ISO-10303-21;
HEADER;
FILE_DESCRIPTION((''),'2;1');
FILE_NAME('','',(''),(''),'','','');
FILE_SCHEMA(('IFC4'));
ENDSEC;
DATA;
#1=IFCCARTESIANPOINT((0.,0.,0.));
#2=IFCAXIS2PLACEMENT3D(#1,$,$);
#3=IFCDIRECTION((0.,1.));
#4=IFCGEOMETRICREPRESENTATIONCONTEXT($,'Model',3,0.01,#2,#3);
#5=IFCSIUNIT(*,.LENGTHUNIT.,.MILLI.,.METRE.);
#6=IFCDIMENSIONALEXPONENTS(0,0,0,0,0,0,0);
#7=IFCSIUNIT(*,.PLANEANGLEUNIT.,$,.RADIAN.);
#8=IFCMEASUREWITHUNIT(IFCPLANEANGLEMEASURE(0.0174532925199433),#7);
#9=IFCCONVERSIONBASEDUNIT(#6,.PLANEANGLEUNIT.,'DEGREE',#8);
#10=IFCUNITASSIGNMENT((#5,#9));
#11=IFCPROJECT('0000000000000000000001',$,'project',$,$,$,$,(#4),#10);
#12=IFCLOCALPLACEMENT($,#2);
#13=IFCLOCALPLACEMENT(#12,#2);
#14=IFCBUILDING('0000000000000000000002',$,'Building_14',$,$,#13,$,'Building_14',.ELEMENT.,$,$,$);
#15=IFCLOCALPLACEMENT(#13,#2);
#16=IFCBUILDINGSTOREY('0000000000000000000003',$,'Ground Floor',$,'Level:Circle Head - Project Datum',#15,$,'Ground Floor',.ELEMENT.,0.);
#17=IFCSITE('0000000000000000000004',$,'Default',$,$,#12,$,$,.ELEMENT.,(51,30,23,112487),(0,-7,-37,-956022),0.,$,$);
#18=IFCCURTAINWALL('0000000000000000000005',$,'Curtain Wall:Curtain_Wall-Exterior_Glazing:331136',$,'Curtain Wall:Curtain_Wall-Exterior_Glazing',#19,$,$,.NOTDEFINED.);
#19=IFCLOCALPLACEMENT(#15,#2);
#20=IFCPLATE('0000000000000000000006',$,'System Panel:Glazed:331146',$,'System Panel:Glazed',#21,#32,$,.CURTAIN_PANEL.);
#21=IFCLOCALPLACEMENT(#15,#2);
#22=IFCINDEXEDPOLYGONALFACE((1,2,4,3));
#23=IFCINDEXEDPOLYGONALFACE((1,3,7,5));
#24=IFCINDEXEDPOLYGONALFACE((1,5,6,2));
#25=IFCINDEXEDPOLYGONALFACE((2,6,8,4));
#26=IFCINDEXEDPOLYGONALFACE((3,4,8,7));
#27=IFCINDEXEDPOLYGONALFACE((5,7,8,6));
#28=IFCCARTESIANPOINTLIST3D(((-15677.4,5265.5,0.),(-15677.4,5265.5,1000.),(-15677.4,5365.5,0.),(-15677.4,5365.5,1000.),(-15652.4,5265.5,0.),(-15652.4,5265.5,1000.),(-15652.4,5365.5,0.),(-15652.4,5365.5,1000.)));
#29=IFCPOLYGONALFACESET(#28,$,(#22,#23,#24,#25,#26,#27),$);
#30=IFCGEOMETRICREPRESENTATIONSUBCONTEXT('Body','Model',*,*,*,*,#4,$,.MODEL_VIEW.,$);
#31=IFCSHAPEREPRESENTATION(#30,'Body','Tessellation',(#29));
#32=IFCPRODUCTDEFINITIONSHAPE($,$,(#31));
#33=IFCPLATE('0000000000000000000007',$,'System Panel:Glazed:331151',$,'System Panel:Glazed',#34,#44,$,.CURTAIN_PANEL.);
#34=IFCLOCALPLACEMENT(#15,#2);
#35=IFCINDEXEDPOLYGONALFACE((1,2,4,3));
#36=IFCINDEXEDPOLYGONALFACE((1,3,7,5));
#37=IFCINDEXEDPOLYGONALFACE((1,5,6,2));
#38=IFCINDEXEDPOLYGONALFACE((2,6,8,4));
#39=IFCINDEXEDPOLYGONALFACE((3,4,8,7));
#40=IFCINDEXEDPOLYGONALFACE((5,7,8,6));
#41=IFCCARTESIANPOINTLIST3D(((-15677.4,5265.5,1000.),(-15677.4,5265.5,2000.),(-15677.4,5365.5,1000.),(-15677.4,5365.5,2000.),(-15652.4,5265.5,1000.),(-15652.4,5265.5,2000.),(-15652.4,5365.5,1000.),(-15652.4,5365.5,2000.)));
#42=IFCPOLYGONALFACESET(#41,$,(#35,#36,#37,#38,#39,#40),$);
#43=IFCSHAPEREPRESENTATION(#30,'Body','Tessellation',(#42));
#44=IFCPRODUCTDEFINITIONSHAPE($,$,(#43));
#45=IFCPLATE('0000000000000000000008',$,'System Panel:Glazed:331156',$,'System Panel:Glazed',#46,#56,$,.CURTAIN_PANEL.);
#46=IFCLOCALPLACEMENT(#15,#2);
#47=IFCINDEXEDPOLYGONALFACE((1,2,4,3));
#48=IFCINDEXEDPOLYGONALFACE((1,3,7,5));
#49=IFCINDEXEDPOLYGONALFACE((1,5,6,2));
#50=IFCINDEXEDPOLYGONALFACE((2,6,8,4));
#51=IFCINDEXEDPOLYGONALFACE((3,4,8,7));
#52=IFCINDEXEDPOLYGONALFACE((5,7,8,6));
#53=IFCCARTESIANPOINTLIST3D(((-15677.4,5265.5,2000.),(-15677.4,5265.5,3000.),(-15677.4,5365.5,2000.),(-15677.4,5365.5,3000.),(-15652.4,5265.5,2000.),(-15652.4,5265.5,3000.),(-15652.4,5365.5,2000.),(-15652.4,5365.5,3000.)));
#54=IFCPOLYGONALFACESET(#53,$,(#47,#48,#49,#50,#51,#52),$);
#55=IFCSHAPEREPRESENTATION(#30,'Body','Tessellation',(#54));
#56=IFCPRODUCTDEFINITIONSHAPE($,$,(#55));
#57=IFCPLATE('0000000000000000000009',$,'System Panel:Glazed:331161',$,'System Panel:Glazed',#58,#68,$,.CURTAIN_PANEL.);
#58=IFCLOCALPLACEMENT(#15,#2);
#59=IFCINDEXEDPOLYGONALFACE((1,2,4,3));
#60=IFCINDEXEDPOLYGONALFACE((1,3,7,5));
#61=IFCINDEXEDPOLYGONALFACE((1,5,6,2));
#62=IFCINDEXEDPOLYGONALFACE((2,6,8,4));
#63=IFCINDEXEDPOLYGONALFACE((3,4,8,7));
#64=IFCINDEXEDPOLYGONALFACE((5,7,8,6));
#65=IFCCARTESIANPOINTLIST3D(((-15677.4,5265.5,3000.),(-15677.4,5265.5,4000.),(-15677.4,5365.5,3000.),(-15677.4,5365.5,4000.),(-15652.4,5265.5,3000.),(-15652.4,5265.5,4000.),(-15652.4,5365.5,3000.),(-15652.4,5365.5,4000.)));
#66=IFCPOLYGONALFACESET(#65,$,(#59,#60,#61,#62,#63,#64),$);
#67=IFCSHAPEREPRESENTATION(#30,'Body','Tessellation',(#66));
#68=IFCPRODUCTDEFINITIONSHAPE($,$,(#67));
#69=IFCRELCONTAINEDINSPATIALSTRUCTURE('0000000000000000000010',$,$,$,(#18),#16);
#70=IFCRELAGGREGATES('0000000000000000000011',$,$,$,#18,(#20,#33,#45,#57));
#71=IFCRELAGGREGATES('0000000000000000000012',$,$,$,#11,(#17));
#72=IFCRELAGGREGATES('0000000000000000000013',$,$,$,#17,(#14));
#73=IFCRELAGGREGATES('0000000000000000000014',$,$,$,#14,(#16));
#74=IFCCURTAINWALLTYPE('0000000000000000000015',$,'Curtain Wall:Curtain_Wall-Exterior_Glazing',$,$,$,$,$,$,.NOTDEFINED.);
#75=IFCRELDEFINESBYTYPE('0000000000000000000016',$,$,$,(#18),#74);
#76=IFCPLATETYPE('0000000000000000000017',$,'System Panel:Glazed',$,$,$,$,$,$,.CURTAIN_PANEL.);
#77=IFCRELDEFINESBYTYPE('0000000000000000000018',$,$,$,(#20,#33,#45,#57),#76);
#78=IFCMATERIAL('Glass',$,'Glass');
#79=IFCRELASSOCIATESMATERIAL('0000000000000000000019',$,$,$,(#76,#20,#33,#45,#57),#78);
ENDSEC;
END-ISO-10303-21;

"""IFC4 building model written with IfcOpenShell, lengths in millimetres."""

from ifc_helpers import new_model, entity, si_unit, converted_unit, direction, frame, origin, place, context, subcontext, project, spatial, indexed_curve, outline, extrude, source, transform, mapped, material, type_object, type_shapes, element, aggregate, save


model = new_model("IFC4")

# Units and contexts
model_context = context("Model", 3, precision=0.01, world=origin(), true_north=direction((0.0, 1.0)))
body_context = subcontext(model_context, "Body", "Model", "MODEL_VIEW")
ifc_project = project(units=[si_unit("LENGTHUNIT", "METRE", prefix="MILLI"), converted_unit("PLANEANGLEUNIT", "DEGREE", entity("IfcPlaneAngleMeasure", 0.0174532925199433), si_unit("PLANEANGLEUNIT", "RADIAN"), dimensions=[0, 0, 0, 0, 0, 0, 0])], contexts=[model_context])

# Site, building, storey
site_placement = place(None, origin())
site = spatial("IfcSite", under=ifc_project, at=site_placement, Name="Default", CompositionType="ELEMENT", RefLatitude=(51, 30, 23, 112487), RefLongitude=(0, -7, -37, -956022), RefElevation=0.0)
building_placement = place(site_placement, origin())
building = spatial("IfcBuilding", under=site, at=building_placement, Name="Building_14", LongName="Building_14", CompositionType="ELEMENT")
storey_placement = place(building_placement, origin())
storey = spatial("IfcBuildingStorey", under=building, at=storey_placement, Name="Ground Floor", ObjectType="Level:Circle Head - Project Datum", LongName="Ground Floor", CompositionType="ELEMENT", Elevation=0.0)

# Curtain wall
curtain_wall_type = type_object("IfcCurtainWallType", Name="Curtain Wall:Curtain_Wall-Exterior_Glazing", PredefinedType="NOTDEFINED")
ifc_material = material(Name="Glass", Category="Glass")
curtain_wall_1_placement = place(storey_placement, origin())
curtain_wall_1 = element("IfcCurtainWall", 1, at=curtain_wall_1_placement, inside=storey, type_object=curtain_wall_type, Name="Curtain Wall:Curtain_Wall-Exterior_Glazing:331136", ObjectType="Curtain Wall:Curtain_Wall-Exterior_Glazing", PredefinedType="NOTDEFINED")

# Plates
plate_type_1 = type_object("IfcPlateType", Name="System Panel:Glazed", PredefinedType="CURTAIN_PANEL", material=ifc_material)
shared_shape_1 = source(origin(), body_context, "Body", "SweptSolid", [
    extrude(outline(indexed_curve([(-12.5, -50.0), (12.5, -50.0), (12.5, 50.0), (-12.5, 50.0), (-12.5, -50.0)], self_intersect=False)), frame((0.0, -37.0, 0.0), z_axis=(0.0, 0.0, 1.0), x_axis=(0.0, 1.0, 0.0)), (0.0, 0.0, 1.0), 1000.0),
])
type_shapes(plate_type_1, [shared_shape_1])
plate_1_placement = place(curtain_wall_1_placement, frame((-15701.9, 5315.5, 0.0), z_axis=(0.0, 0.0, 1.0), x_axis=(0.0, 1.0, 0.0)))
plate_1 = element("IfcPlate", 2, at=plate_1_placement, type_object=plate_type_1, material=ifc_material, Name="System Panel:Glazed:331146", ObjectType="System Panel:Glazed", PredefinedType="CURTAIN_PANEL", context=body_context, shape_type="MappedRepresentation", body=[
    mapped(shared_shape_1, transform((0.0, 0.0, 0.0), scale=1.0)),
])
plate_2_placement = place(curtain_wall_1_placement, frame((-15701.9, 5315.5, 1000.0), z_axis=(0.0, 0.0, 1.0), x_axis=(0.0, 1.0, 0.0)))
plate_2 = element("IfcPlate", 3, at=plate_2_placement, type_object=plate_type_1, material=ifc_material, Name="System Panel:Glazed:331151", ObjectType="System Panel:Glazed", PredefinedType="CURTAIN_PANEL", context=body_context, shape_type="MappedRepresentation", body=[
    mapped(shared_shape_1, transform((0.0, 0.0, 0.0), scale=1.0)),
])
plate_3_placement = place(curtain_wall_1_placement, frame((-15701.9, 5315.5, 2000.0), z_axis=(0.0, 0.0, 1.0), x_axis=(0.0, 1.0, 0.0)))
plate_3 = element("IfcPlate", 4, at=plate_3_placement, type_object=plate_type_1, material=ifc_material, Name="System Panel:Glazed:331156", ObjectType="System Panel:Glazed", PredefinedType="CURTAIN_PANEL", context=body_context, shape_type="MappedRepresentation", body=[
    mapped(shared_shape_1, transform((0.0, 0.0, 0.0), scale=1.0)),
])
plate_4_placement = place(curtain_wall_1_placement, frame((-15701.9, 5315.5, 3000.0), z_axis=(0.0, 0.0, 1.0), x_axis=(0.0, 1.0, 0.0)))
plate_4 = element("IfcPlate", 5, at=plate_4_placement, type_object=plate_type_1, material=ifc_material, Name="System Panel:Glazed:331161", ObjectType="System Panel:Glazed", PredefinedType="CURTAIN_PANEL", context=body_context, shape_type="MappedRepresentation", body=[
    mapped(shared_shape_1, transform((0.0, 0.0, 0.0), scale=1.0)),
])
aggregate(curtain_wall_1, [plate_1, plate_2, plate_3, plate_4])

save(model, "model.ifc")
